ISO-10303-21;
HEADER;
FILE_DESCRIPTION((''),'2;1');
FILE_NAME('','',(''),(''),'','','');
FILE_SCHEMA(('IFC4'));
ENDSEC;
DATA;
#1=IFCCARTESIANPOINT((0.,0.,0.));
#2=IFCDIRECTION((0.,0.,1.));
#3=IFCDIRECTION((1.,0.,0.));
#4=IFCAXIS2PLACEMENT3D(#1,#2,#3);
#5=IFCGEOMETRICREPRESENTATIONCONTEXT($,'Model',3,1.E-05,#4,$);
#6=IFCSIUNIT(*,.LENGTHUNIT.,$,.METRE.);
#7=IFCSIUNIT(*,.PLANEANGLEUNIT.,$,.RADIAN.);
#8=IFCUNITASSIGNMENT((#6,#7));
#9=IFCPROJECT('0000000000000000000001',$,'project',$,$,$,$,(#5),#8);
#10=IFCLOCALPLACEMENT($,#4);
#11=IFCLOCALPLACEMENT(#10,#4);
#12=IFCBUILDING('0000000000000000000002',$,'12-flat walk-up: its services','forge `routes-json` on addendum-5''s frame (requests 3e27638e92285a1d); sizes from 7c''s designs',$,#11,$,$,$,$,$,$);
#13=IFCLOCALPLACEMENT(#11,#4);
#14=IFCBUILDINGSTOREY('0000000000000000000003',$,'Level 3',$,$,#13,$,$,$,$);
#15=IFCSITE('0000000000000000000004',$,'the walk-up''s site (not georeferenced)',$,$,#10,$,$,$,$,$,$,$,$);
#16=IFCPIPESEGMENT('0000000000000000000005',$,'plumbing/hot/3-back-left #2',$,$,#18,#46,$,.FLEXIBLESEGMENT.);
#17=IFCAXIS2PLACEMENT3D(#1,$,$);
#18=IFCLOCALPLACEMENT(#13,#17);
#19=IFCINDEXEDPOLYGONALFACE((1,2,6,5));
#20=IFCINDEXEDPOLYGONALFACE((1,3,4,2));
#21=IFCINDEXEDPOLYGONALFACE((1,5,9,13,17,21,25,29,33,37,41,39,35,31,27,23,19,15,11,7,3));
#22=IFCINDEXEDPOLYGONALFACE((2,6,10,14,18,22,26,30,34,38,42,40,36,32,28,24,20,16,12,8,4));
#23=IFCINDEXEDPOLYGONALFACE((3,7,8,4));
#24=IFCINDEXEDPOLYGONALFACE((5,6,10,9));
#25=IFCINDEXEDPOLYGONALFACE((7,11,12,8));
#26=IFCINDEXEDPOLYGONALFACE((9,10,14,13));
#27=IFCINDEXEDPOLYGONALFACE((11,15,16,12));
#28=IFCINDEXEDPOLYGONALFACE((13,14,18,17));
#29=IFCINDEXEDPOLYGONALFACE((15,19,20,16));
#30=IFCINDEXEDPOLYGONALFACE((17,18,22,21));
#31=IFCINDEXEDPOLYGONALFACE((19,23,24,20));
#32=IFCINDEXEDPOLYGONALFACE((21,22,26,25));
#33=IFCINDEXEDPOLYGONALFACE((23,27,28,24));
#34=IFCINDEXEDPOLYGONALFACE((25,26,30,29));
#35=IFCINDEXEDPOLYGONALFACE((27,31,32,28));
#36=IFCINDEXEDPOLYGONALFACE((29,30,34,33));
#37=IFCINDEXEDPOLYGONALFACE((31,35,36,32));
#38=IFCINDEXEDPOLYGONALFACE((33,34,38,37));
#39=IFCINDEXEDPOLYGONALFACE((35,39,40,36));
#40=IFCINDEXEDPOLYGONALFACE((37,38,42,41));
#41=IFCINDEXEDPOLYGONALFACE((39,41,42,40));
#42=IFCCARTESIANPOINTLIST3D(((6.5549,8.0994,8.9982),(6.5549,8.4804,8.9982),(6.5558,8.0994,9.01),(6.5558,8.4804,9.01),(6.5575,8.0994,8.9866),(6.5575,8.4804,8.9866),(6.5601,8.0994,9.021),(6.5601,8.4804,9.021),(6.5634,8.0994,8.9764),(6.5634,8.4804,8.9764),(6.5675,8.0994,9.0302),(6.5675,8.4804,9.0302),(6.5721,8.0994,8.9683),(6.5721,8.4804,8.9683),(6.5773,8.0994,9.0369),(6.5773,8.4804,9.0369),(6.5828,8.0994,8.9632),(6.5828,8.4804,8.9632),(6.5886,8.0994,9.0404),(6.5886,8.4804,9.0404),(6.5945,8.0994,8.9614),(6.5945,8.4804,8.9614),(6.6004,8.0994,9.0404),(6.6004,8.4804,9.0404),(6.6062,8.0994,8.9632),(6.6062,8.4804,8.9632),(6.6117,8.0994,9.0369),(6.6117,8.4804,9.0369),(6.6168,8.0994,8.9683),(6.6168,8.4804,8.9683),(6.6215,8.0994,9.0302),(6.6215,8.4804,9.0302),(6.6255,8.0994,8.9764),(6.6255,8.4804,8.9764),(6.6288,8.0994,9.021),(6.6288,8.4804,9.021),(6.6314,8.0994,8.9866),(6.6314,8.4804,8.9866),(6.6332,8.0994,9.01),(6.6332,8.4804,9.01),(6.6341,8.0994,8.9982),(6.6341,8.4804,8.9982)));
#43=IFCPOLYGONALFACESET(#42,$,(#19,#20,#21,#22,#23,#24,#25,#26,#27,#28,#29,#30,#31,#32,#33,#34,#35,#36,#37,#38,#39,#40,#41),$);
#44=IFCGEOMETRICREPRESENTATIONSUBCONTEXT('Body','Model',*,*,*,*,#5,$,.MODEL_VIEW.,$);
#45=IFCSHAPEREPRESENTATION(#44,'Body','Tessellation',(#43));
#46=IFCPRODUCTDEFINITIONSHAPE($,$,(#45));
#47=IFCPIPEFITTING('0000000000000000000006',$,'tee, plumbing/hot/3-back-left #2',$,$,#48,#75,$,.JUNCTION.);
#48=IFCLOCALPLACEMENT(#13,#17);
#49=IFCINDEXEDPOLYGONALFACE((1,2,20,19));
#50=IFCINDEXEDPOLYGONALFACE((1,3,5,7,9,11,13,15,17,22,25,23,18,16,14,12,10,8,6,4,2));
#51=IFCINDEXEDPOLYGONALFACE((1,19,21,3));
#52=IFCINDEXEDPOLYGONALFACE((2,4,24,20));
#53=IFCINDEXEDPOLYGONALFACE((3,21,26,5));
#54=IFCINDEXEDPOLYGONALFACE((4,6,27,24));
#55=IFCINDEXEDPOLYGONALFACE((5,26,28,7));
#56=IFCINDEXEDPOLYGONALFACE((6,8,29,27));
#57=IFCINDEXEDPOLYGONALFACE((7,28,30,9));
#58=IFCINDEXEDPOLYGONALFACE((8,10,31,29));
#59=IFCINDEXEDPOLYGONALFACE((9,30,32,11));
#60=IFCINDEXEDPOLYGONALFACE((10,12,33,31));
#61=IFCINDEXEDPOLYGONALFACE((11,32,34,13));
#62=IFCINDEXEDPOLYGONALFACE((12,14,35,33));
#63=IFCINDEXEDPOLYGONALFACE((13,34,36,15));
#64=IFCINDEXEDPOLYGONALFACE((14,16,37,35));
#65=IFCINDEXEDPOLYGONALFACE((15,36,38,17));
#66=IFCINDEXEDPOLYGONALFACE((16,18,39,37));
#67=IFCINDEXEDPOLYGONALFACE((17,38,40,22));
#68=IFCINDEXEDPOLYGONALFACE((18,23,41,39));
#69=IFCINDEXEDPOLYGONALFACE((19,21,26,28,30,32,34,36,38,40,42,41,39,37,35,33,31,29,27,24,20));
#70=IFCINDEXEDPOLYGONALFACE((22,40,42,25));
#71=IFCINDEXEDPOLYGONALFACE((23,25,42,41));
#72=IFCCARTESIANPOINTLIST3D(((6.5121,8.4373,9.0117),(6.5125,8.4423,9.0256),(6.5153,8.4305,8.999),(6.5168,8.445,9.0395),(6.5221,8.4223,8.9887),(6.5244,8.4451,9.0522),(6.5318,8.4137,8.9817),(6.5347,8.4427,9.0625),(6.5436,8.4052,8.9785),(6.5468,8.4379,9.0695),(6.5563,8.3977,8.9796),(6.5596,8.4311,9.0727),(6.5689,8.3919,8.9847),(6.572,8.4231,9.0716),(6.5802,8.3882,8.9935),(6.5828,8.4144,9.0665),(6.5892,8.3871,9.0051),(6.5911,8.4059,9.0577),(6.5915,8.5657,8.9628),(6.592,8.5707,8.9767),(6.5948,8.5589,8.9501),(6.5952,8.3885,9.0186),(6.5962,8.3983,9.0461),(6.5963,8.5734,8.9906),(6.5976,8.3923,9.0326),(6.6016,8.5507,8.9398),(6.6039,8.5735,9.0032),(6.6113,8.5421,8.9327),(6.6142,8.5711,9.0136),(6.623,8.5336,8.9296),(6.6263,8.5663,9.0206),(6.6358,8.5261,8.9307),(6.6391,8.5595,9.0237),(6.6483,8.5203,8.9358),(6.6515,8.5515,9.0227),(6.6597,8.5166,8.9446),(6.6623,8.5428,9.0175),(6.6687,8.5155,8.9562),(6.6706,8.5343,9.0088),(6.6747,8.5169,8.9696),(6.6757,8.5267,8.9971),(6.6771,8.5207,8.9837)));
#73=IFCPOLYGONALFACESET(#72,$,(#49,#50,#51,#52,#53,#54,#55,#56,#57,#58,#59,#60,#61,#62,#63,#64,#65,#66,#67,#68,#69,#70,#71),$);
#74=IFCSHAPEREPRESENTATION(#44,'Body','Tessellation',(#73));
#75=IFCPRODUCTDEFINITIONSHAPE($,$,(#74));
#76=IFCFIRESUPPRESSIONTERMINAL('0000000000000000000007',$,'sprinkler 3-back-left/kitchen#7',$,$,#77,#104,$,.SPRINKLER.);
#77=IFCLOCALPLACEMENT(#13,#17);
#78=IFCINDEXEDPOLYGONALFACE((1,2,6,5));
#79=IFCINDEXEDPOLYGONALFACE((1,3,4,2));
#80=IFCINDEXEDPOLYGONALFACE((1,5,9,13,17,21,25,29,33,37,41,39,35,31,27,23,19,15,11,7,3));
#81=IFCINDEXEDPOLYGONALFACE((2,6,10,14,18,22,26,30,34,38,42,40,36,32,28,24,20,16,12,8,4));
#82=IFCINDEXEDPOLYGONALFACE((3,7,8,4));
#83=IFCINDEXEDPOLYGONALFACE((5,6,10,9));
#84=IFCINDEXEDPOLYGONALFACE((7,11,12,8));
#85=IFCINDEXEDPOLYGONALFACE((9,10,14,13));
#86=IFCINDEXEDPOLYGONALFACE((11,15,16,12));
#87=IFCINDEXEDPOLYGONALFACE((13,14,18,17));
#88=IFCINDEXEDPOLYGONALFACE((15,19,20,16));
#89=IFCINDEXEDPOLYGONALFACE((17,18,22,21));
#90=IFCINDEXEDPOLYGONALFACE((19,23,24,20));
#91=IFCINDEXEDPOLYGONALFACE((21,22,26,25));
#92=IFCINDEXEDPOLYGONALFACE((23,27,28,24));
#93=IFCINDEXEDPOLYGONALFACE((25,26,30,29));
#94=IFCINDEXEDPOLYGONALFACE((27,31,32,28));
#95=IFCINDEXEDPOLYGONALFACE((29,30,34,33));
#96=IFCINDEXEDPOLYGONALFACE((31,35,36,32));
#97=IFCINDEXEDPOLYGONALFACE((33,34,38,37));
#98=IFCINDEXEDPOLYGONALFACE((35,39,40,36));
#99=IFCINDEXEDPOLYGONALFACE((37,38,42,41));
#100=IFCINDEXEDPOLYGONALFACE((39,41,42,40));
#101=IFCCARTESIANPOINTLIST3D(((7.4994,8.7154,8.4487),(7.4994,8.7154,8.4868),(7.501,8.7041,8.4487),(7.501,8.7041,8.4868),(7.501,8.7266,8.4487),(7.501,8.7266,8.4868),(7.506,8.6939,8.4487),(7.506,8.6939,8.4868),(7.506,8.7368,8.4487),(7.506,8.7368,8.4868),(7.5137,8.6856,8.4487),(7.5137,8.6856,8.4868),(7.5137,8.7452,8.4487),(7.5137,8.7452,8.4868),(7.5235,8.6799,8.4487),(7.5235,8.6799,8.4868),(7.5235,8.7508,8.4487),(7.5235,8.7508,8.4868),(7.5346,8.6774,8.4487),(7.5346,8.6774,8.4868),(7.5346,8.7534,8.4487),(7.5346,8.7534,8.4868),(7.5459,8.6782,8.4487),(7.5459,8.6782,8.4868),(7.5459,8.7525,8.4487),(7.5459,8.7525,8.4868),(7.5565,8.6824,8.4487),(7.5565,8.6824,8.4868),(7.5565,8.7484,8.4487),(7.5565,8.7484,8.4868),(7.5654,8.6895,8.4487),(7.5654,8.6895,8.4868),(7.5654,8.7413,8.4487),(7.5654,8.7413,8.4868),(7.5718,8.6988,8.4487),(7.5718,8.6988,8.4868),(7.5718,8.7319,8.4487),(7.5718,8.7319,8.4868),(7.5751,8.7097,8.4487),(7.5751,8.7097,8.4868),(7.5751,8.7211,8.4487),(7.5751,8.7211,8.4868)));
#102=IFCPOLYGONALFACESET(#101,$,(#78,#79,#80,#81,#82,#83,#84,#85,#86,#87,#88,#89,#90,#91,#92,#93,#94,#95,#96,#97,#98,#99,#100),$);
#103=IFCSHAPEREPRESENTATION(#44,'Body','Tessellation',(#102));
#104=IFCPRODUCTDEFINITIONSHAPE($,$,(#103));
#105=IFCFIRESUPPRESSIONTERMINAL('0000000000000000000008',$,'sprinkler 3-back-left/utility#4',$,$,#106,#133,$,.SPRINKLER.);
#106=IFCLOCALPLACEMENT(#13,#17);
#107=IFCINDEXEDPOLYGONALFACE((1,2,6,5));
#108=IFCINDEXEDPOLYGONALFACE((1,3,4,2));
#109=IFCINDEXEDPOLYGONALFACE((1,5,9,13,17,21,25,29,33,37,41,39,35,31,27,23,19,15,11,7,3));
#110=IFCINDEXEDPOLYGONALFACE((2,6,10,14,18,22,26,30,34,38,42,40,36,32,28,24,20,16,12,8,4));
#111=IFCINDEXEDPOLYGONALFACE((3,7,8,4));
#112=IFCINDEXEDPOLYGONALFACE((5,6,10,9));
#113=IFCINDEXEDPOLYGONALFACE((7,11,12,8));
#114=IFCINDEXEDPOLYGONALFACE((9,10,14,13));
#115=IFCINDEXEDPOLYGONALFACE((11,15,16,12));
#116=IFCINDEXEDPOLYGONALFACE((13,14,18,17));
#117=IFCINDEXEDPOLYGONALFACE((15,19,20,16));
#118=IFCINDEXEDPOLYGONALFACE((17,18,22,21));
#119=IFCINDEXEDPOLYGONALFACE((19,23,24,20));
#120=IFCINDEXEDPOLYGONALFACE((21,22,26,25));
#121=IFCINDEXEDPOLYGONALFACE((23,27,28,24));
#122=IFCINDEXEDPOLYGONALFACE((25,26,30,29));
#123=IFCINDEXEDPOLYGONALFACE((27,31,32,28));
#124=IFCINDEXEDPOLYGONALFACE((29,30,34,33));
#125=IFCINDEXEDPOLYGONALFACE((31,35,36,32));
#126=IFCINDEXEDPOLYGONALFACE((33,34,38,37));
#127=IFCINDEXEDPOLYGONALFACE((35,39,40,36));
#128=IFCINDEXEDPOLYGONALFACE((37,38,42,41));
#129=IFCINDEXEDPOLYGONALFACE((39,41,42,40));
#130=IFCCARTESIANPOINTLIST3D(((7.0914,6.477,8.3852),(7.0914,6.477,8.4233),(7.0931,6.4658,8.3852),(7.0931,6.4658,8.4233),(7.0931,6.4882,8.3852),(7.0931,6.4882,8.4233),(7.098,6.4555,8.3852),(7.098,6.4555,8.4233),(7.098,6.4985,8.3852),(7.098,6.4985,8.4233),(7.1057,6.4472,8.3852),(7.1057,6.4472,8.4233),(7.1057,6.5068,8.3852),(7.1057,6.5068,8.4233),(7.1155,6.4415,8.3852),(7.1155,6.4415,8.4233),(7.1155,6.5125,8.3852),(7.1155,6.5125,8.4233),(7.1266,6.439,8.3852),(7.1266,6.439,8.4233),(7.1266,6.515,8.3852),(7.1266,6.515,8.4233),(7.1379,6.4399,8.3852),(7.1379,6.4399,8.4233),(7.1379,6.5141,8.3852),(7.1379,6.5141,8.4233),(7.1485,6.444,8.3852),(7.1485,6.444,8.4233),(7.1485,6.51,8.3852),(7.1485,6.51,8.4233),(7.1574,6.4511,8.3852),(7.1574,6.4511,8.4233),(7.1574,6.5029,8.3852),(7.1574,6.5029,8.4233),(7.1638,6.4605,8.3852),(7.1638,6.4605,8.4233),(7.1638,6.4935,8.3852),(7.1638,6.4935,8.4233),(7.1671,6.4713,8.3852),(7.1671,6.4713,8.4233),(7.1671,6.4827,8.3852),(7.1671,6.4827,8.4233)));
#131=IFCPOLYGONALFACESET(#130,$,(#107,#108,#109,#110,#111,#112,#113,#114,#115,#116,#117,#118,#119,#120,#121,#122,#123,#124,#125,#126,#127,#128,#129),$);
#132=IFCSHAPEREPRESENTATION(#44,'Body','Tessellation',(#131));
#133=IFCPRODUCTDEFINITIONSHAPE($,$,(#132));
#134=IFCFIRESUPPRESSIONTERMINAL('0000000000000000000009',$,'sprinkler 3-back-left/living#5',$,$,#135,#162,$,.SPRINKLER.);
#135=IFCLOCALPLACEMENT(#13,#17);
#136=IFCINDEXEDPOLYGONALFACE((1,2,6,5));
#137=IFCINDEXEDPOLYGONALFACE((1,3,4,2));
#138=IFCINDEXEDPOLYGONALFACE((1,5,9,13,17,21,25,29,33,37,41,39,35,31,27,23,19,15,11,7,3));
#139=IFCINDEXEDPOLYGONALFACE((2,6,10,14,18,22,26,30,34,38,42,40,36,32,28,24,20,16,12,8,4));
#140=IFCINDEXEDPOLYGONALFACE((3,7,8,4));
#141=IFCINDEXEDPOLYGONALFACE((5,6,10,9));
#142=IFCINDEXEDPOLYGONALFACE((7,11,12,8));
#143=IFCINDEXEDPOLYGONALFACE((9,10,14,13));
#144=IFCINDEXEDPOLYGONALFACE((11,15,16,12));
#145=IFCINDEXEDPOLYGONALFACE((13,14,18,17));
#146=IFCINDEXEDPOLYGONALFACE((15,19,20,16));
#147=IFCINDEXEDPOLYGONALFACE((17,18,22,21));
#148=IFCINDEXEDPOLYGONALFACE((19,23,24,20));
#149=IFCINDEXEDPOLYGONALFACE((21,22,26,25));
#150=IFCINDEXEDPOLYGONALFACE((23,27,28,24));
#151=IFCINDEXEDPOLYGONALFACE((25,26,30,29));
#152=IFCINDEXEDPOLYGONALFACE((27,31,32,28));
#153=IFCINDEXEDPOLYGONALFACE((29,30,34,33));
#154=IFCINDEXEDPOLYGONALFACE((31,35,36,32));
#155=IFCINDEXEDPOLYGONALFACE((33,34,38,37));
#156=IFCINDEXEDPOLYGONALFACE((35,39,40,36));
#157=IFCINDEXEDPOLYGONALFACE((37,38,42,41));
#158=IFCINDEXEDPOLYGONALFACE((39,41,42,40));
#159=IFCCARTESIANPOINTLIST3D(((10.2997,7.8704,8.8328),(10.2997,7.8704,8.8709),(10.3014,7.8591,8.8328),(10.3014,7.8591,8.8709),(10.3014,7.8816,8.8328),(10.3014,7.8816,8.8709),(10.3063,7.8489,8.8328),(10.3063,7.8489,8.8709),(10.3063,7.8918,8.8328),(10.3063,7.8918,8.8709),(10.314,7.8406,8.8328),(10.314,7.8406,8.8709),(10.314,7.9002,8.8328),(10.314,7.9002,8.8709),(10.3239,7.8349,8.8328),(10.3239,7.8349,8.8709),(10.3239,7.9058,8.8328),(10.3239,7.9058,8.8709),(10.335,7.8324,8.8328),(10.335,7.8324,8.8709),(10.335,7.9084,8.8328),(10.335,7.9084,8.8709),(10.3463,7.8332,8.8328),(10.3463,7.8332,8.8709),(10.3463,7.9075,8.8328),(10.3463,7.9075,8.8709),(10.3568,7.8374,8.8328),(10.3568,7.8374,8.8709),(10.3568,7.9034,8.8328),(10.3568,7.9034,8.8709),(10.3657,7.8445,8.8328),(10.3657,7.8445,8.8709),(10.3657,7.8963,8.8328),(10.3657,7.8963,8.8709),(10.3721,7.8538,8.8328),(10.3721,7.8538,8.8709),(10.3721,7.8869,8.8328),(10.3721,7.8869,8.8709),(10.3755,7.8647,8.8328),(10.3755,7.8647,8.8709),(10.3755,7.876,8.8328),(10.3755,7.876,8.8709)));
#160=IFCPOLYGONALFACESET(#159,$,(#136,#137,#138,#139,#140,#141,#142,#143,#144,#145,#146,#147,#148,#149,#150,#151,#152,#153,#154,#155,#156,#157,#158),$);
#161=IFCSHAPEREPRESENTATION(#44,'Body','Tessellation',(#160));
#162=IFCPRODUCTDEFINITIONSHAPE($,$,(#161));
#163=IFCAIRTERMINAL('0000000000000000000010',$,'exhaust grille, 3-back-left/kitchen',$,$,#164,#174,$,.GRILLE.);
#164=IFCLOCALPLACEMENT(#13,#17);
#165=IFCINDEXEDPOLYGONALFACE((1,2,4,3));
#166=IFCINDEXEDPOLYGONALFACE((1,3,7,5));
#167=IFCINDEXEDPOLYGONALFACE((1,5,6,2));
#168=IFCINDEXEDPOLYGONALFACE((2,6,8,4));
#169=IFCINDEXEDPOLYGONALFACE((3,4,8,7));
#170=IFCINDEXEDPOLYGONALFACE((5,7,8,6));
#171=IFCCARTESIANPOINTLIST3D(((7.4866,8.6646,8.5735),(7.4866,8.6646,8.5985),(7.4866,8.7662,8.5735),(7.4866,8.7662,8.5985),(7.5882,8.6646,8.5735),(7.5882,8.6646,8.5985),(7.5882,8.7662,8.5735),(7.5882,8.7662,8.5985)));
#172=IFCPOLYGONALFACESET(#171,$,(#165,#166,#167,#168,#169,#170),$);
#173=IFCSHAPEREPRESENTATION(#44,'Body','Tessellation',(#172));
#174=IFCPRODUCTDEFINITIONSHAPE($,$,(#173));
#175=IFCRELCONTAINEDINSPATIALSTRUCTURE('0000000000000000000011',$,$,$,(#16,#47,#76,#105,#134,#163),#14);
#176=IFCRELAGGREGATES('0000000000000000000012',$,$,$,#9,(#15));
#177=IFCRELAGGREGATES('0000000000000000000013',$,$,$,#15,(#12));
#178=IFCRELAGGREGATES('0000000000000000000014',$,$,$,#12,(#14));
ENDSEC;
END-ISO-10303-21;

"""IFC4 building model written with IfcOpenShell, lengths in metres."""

from ifc_helpers import new_model, entity, si_unit, frame, frame_2d, origin, origin_with_axes, place, context, subcontext, project, spatial, rectangle, extrude, element, save


model = new_model("IFC4")

# Units and contexts
model_context = context("Model", 3, precision=1e-05, world=origin_with_axes())
body_context = subcontext(model_context, "Body", "Model", "MODEL_VIEW")
ifc_project = project(units=[si_unit("LENGTHUNIT", "METRE"), si_unit("PLANEANGLEUNIT", "RADIAN")], contexts=[model_context])

# Site, building, storey
site_placement = place(None, origin_with_axes())
site = spatial("IfcSite", under=ifc_project, at=site_placement, Name="the walk-up's site (not georeferenced)")
building_placement = place(site_placement, origin_with_axes())
building = spatial("IfcBuilding", under=site, at=building_placement, Name="12-flat walk-up: its services", Description="forge `routes-json` on addendum-5's frame (requests 3e27638e92285a1d); sizes from 7c's designs")
storey_placement = place(building_placement, origin_with_axes())
storey = spatial("IfcBuildingStorey", under=building, at=storey_placement, Name="Level 3")

# Pipe segment
pipe_segment_1_placement = place(storey_placement, frame((6.5945, 8.4804, 9.0011), z_axis=(0.0, 0.0, 1.0), x_axis=(1.0, 0.0, 0.0)))
element("IfcPipeSegment", 1, at=pipe_segment_1_placement, inside=storey, Name="plumbing/hot/3-back-left #2", PredefinedType="FLEXIBLESEGMENT", context=body_context, shape_type="AdvancedSweptSolid", body=[
    entity("IfcSweptDiskSolid", entity("IfcPolyline", [entity("IfcCartesianPoint", [0.0, 0.0, 0.0]), entity("IfcCartesianPoint", [0.0, -0.381, 0.0])]), 0.0397),
])

# Pipe fitting
pipe_fitting_1_placement = place(storey_placement, frame((6.6342, 8.5446, 8.9767), z_axis=(0.0, 0.0, 1.0), x_axis=(1.0, 0.0, 0.0)))
element("IfcPipeFitting", 2, at=pipe_fitting_1_placement, inside=storey, Name="tee, plumbing/hot/3-back-left #2", PredefinedType="JUNCTION", context=body_context, shape_type="AdvancedSweptSolid", body=[
    entity("IfcSweptDiskSolid", entity("IfcPolyline", [entity("IfcCartesianPoint", [0.0, 0.0, 0.0]), entity("IfcCartesianPoint", [-0.0795, -0.1284, 0.0489])]), 0.0496),
])

# Fire suppression terminals
for number, where, z_axis, x_axis, name in (
    (3, (7.5374, 8.7154, 8.4868), (0.0, 0.0, 1.0), (1.0, 0.0, 0.0), "sprinkler 3-back-left/kitchen#7"),
    (4, (7.1295, 6.477, 8.4233), (0.0, 0.0, 1.0), (1.0, 0.0, 0.0), "sprinkler 3-back-left/utility#4"),
    (5, (10.3378, 7.8704, 8.8709), (0.0, 0.0, 1.0), (1.0, 0.0, 0.0), "sprinkler 3-back-left/living#5"),
):
    element("IfcFireSuppressionTerminal", number, at=place(storey_placement, frame(where, z_axis=z_axis, x_axis=x_axis)), inside=storey, Name=name, PredefinedType="SPRINKLER", context=body_context, shape_type="AdvancedSweptSolid", body=[
        entity("IfcSweptDiskSolid", entity("IfcPolyline", [entity("IfcCartesianPoint", [0.0, 0.0, 0.0]), entity("IfcCartesianPoint", [0.0, 0.0, -0.0381])]), 0.0381),
    ])

# Air terminal
air_terminal_placement = place(storey_placement, frame((7.4867, 8.6646, 8.5735), z_axis=(0.0, 0.0, 1.0), x_axis=(1.0, 0.0, 0.0)))
element("IfcAirTerminal", 6, at=air_terminal_placement, inside=storey, Name="exhaust grille, 3-back-left/kitchen", PredefinedType="GRILLE", context=body_context, shape_type="SweptSolid", body=[
    extrude(rectangle(XDim=0.1016, YDim=0.1016, at=frame_2d((0.0508, 0.0508))), origin(), (0.0, 0.0, 1.0), 0.025),
])

save(model, "model.ifc")
